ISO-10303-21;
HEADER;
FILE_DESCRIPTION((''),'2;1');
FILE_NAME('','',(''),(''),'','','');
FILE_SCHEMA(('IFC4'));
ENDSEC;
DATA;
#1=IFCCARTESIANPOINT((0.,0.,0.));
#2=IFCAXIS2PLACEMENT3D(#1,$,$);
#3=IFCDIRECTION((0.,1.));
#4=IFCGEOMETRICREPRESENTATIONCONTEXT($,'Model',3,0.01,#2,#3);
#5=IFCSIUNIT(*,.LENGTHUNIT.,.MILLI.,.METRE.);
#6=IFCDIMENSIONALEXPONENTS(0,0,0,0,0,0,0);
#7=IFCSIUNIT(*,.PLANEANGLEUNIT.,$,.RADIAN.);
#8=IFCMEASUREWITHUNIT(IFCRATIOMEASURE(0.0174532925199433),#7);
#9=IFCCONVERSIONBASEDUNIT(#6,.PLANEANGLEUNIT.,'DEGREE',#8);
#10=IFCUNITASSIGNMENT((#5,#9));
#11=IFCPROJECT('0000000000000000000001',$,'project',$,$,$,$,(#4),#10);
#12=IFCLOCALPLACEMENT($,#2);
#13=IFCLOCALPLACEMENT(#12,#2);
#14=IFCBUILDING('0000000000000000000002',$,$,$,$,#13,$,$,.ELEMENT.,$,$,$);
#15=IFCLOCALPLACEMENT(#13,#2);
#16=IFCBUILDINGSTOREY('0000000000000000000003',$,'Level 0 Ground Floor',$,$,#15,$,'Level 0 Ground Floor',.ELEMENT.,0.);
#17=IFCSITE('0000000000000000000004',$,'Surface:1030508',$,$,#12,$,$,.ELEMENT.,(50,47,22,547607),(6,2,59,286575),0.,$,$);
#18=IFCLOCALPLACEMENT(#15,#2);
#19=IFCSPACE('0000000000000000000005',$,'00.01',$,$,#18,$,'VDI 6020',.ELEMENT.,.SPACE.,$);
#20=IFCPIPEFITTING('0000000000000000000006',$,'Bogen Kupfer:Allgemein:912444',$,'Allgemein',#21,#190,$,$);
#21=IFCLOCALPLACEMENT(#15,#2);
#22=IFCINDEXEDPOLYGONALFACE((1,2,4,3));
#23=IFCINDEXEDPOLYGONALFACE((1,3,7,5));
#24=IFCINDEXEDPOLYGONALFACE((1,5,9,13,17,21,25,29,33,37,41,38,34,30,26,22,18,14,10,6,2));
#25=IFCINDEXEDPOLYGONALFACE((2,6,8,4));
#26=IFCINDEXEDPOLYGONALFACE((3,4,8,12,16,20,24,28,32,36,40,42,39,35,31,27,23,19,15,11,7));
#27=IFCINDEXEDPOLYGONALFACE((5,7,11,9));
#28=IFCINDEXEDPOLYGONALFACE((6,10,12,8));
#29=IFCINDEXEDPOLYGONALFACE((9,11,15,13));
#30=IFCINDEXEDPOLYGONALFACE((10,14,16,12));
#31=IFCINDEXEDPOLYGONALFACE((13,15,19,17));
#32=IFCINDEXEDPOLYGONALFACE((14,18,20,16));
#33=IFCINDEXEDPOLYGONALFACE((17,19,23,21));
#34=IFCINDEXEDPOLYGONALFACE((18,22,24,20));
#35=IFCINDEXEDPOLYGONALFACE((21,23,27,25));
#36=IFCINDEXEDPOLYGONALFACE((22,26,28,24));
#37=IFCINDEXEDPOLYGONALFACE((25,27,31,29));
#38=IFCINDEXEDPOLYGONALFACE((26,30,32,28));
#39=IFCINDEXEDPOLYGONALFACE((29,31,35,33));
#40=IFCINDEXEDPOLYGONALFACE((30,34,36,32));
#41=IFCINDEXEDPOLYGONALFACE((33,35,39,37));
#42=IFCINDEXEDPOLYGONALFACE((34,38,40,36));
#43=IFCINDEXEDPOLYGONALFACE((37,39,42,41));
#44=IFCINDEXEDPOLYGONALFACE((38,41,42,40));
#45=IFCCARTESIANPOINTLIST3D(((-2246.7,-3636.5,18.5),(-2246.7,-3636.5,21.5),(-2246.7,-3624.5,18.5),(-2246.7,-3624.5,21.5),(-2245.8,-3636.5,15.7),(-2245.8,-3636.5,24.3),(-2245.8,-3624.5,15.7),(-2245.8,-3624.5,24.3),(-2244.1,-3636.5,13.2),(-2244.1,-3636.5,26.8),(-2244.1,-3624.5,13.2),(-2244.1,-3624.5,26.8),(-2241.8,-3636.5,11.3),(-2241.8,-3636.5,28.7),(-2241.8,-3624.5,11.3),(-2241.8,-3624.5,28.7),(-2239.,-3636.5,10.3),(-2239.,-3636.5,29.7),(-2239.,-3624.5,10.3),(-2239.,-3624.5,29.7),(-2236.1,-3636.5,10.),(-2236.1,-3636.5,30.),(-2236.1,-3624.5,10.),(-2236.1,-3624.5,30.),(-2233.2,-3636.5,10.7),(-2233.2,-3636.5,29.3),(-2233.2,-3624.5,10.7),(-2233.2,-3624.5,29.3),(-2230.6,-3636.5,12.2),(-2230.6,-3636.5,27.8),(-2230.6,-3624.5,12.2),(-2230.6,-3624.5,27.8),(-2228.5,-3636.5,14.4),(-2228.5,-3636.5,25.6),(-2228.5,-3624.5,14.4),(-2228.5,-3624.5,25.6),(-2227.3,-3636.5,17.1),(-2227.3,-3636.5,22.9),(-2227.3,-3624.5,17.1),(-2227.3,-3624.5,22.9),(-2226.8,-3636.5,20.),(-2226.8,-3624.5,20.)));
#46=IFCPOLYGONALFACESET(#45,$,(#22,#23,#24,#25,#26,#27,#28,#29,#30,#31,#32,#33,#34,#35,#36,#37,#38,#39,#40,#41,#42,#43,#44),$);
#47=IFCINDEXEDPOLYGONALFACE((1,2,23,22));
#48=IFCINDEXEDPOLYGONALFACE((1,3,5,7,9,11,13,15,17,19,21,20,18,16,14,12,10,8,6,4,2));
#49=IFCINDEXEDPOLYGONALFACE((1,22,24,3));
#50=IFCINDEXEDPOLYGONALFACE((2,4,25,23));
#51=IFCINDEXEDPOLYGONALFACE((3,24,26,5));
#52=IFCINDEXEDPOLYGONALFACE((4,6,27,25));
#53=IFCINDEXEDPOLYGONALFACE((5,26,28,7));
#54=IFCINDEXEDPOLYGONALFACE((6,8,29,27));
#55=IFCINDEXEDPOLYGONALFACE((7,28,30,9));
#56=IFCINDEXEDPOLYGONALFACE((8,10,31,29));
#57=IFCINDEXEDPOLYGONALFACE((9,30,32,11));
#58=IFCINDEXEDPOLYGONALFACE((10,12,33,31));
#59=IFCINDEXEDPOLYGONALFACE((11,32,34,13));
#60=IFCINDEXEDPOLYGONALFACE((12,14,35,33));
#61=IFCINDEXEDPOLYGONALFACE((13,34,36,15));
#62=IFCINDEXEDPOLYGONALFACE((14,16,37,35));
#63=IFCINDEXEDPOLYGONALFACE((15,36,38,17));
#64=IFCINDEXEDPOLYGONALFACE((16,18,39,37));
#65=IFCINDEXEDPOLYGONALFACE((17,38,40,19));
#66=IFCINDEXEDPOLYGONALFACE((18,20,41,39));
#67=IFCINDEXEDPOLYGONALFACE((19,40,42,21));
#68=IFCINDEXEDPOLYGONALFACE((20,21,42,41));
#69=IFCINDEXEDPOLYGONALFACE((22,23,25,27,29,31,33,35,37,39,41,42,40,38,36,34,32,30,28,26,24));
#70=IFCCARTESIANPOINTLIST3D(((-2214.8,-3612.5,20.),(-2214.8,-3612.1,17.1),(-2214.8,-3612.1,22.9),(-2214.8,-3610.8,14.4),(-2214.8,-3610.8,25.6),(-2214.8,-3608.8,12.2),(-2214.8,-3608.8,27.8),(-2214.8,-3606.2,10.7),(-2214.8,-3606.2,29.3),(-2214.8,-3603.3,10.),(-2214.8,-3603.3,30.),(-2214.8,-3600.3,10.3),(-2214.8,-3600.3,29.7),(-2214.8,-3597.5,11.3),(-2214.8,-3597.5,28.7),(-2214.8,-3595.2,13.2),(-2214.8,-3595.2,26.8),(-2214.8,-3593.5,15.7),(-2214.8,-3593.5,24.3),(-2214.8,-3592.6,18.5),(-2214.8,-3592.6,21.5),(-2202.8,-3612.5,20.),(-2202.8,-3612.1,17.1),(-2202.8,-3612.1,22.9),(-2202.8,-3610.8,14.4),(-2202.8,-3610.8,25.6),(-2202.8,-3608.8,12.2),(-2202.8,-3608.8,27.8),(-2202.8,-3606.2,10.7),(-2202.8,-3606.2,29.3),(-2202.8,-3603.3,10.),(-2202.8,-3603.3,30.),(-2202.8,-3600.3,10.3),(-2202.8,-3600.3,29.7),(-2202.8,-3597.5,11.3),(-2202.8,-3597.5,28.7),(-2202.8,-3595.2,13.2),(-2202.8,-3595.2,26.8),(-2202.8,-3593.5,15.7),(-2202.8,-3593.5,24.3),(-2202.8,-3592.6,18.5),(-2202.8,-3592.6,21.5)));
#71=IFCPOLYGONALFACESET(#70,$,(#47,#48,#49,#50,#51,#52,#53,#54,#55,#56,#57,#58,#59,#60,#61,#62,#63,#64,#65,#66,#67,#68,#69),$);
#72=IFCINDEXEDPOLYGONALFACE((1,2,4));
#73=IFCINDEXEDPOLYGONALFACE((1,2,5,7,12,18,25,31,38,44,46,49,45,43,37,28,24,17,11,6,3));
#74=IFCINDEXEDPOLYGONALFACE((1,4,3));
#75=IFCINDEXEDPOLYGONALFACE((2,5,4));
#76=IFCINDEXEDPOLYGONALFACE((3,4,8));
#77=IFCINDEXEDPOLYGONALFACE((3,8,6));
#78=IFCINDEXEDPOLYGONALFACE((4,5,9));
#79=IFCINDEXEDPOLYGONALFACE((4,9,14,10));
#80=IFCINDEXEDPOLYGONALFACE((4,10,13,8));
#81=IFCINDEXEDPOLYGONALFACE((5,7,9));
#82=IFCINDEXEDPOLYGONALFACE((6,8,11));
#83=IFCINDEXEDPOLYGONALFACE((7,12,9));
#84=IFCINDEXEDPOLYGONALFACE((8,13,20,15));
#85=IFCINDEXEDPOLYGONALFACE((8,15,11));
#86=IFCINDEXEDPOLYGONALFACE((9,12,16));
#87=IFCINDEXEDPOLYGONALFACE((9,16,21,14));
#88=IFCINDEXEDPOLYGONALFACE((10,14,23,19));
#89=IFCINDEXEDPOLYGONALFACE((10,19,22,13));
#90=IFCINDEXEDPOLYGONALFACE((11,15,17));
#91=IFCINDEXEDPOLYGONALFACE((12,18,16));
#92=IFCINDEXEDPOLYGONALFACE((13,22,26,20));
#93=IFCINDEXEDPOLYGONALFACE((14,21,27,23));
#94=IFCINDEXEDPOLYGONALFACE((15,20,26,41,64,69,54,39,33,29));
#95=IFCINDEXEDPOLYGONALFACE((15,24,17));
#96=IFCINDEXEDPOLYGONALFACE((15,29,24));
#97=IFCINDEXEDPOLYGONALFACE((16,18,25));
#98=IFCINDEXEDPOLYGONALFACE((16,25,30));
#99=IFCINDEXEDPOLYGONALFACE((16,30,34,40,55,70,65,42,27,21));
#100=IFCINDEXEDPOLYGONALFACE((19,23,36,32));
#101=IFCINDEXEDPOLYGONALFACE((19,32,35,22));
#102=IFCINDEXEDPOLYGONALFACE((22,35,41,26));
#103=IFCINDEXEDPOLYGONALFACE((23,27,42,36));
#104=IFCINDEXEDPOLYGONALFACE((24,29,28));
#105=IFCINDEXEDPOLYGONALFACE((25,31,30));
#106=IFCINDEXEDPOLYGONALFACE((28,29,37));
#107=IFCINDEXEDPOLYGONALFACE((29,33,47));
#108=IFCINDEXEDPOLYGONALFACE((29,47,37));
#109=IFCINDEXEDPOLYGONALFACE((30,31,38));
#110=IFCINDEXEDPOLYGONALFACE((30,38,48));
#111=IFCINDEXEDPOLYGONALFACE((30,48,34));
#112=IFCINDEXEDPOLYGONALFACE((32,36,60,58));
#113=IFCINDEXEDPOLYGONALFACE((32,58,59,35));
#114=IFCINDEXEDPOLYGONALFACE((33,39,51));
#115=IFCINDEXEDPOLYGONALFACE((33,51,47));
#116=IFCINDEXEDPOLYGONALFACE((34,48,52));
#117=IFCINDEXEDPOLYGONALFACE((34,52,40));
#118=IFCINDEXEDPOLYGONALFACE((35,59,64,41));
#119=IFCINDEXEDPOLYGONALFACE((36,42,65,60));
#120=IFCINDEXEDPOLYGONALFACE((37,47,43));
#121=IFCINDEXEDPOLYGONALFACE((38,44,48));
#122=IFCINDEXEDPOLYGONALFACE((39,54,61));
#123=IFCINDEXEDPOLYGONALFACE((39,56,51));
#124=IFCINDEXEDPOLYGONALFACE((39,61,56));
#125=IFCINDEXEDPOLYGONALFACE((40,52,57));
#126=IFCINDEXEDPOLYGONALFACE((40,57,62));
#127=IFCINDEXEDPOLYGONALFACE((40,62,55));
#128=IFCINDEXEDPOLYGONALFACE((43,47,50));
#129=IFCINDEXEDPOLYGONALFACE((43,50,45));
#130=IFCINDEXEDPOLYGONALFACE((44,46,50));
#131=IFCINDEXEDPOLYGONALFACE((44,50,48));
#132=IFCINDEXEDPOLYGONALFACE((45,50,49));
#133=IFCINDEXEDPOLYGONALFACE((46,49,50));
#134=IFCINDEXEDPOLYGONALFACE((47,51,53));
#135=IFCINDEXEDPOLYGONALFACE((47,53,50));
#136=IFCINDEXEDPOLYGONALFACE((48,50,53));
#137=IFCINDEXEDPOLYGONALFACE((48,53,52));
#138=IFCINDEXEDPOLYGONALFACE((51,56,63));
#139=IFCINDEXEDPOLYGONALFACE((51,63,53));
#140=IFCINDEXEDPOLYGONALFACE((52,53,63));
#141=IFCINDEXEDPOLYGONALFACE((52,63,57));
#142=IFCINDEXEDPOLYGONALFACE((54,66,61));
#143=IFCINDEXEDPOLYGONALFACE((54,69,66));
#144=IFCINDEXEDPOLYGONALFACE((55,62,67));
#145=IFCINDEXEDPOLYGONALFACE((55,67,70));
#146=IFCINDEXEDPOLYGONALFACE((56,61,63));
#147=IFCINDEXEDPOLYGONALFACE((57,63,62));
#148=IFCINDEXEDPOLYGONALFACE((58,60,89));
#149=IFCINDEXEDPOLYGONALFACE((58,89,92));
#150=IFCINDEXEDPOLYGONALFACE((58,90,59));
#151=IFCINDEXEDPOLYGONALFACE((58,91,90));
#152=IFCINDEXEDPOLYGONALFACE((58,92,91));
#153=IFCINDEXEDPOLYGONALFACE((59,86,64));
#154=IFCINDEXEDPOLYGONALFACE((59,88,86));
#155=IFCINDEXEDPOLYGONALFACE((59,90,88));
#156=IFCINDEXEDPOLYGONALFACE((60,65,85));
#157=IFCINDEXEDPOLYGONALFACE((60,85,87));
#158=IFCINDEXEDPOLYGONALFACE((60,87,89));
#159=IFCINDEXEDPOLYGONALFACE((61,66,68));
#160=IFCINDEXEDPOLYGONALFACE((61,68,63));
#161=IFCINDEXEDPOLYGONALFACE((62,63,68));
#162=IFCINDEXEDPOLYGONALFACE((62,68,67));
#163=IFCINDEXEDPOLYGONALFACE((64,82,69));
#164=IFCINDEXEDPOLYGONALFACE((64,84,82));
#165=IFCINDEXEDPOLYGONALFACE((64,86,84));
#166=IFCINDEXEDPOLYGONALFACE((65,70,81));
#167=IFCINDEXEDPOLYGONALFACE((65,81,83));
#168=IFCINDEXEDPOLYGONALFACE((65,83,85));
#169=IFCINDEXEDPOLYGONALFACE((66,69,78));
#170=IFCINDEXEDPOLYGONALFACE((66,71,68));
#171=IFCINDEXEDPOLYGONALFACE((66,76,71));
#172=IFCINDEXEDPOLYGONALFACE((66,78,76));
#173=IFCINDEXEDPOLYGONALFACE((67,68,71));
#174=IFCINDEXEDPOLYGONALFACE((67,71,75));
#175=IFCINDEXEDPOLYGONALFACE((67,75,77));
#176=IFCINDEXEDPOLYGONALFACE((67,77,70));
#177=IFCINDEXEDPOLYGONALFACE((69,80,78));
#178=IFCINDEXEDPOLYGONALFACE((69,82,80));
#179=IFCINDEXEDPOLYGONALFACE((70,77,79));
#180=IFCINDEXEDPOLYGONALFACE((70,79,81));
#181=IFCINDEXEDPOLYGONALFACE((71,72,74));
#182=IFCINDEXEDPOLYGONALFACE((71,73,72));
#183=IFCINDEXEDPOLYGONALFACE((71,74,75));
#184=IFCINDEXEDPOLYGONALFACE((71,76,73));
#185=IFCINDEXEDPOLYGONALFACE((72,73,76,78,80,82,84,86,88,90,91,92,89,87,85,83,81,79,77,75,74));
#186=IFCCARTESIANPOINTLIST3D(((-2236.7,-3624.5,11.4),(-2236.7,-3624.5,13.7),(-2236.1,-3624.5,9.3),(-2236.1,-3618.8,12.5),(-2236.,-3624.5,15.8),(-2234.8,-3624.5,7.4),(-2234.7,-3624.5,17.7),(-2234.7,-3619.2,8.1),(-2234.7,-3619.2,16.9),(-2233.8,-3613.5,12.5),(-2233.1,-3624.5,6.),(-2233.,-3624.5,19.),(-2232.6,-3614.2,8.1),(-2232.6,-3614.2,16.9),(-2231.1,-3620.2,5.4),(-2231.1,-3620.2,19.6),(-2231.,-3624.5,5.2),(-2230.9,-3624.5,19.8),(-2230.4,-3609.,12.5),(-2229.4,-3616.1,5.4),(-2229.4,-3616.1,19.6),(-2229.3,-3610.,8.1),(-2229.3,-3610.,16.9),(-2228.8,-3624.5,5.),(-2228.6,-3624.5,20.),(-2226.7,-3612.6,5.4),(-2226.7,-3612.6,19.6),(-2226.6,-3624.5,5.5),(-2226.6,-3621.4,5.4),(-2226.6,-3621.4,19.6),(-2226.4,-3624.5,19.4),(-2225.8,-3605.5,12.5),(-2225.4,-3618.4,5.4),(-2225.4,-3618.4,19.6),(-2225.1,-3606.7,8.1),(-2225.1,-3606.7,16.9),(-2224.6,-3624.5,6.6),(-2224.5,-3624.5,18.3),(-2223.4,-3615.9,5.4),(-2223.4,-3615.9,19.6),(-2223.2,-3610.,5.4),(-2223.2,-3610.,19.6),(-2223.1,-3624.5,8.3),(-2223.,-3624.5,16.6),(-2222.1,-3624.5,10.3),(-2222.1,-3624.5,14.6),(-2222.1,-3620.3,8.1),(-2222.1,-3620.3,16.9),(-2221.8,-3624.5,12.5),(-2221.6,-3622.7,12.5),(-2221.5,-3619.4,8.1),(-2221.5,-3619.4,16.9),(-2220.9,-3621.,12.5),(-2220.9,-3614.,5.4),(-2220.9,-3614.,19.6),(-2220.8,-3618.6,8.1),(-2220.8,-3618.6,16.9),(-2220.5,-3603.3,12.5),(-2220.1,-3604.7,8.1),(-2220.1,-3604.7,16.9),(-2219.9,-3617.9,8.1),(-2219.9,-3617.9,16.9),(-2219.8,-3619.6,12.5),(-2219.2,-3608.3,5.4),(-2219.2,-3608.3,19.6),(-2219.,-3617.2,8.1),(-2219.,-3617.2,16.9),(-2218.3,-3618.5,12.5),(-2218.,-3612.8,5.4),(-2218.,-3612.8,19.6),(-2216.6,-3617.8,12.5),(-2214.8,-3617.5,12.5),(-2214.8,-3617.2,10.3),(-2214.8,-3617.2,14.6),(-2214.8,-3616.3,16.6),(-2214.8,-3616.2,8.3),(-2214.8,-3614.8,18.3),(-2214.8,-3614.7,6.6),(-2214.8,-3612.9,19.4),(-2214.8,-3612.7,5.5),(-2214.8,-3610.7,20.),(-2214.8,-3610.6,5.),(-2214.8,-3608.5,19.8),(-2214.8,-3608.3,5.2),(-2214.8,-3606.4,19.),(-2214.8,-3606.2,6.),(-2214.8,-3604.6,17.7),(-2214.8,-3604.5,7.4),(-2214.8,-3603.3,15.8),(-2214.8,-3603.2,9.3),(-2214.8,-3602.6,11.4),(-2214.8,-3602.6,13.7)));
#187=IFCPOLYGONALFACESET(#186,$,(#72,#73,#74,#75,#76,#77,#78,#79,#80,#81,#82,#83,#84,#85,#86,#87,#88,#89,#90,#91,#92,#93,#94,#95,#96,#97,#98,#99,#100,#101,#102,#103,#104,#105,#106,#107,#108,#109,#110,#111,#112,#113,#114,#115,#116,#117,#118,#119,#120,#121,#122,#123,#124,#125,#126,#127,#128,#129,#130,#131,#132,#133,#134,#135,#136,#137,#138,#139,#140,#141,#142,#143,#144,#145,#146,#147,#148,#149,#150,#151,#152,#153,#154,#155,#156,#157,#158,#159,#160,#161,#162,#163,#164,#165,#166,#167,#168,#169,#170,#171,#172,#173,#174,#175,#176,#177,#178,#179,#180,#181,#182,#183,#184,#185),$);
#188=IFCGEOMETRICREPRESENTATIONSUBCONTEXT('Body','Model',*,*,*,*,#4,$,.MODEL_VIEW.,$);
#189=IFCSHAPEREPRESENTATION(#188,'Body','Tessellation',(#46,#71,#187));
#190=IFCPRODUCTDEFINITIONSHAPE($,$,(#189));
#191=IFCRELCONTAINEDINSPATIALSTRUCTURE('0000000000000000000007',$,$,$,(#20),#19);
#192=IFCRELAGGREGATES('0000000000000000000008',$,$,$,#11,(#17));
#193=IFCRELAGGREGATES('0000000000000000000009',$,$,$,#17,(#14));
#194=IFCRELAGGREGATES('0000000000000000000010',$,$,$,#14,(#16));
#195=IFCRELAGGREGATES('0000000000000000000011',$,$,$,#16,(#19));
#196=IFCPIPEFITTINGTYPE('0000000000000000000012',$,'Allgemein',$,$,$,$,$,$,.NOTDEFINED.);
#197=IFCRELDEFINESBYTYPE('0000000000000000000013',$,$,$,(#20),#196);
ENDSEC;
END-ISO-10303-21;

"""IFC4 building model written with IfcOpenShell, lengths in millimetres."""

from ifc_helpers import new_model, entity, si_unit, converted_unit, direction, frame, frame_2d, origin, place, context, subcontext, project, spatial, circle, extrude, source, transform, mapped, type_object, type_shapes, element, save


model = new_model("IFC4")

# Units and contexts
model_context = context("Model", 3, precision=0.01, world=origin(), true_north=direction((0.0, 1.0)))
body_context = subcontext(model_context, "Body", "Model", "MODEL_VIEW")
ifc_project = project(units=[si_unit("LENGTHUNIT", "METRE", prefix="MILLI"), converted_unit("PLANEANGLEUNIT", "DEGREE", entity("IfcRatioMeasure", 0.0174532925199433), si_unit("PLANEANGLEUNIT", "RADIAN"), dimensions=[0, 0, 0, 0, 0, 0, 0])], contexts=[model_context])

# Site, building, storey
site_placement = place(None, origin())
site = spatial("IfcSite", under=ifc_project, at=site_placement, Name="Surface:1030508", CompositionType="ELEMENT", RefLatitude=(50, 47, 22, 547607), RefLongitude=(6, 2, 59, 286575), RefElevation=0.0)
building_placement = place(site_placement, origin())
building = spatial("IfcBuilding", under=site, at=building_placement, CompositionType="ELEMENT")
storey_placement = place(building_placement, origin())
storey = spatial("IfcBuildingStorey", under=building, at=storey_placement, Name="Level 0 Ground Floor", LongName="Level 0 Ground Floor", CompositionType="ELEMENT", Elevation=0.0)

# Shared definitions
pipe_fitting_type_1 = type_object("IfcPipeFittingType", Name="Allgemein", PredefinedType="NOTDEFINED")
ifc_direction_1 = entity("IfcDirection", [0.0, 0.0, -1.0])
trimmed_curve_1 = entity("IfcTrimmedCurve", entity("IfcCircle", entity("IfcAxis2Placement2D", entity("IfcCartesianPoint", [-14.5, 0.0]), entity("IfcDirection", [0.0, 1.0])), 14.5), [entity("IfcParameterValue", 270.0)], [entity("IfcParameterValue", 0.0)], True, "PARAMETER")
shared_shape_1 = source(origin(), body_context, "Body", "SolidModel", [
    extrude(circle(Radius=10.0, at=frame_2d((0.0, 0.0), x_axis=(1.0, 0.0))), frame((0.0, 22.0, 0.0), z_axis=(0.0, 1.0, 0.0), x_axis=(-1.0, 0.0, 0.0)), (0.0, 0.0, 1.0), 12.0),
    extrude(circle(Radius=10.0, at=frame_2d((0.0, 0.0), x_axis=(1.0, 0.0))), frame((-34.0, 0.0, 0.0), z_axis=(1.0, 0.0, 0.0), x_axis=(0.0, 1.0, 0.0)), (0.0, 0.0, 1.0), 12.0),
    entity("IfcSurfaceCurveSweptAreaSolid", entity("IfcCircleProfileDef", "AREA", None, entity("IfcAxis2Placement2D", entity("IfcCartesianPoint", [0.0, 7.5]), entity("IfcDirection", [1.0, 0.0])), 7.5), entity("IfcAxis2Placement3D", entity("IfcCartesianPoint", [-7.5, 22.0, 0.0]), ifc_direction_1, entity("IfcDirection", [1.0, 0.0, 0.0])), trimmed_curve_1, 0.0, 90.0, entity("IfcSurfaceOfLinearExtrusion", entity("IfcArbitraryOpenProfileDef", "CURVE", None, trimmed_curve_1), entity("IfcAxis2Placement3D", entity("IfcCartesianPoint", [0.0, 0.0, -304.8])), ifc_direction_1, 1.0)),
])
type_shapes(pipe_fitting_type_1, [shared_shape_1])

# Shared definitions
space_placement = place(storey_placement, origin())
space = spatial("IfcSpace", under=storey, at=space_placement, Name="00.01", LongName="VDI 6020", CompositionType="ELEMENT", PredefinedType="SPACE")

# Pipe fitting
pipe_fitting_1_placement = place(space_placement, frame((-2236.8, -3602.5, 20.0), z_axis=(0.0, 0.0, 1.0), x_axis=(-1.0, 0.0, 0.0)))
element("IfcPipeFitting", 1, at=pipe_fitting_1_placement, inside=space, type_object=pipe_fitting_type_1, Name="Bogen Kupfer:Allgemein:912444", ObjectType="Allgemein", context=body_context, shape_type="MappedRepresentation", body=[
    mapped(shared_shape_1, transform((0.0, 0.0, 0.0), scale=1.0)),
])

save(model, "model.ifc")
